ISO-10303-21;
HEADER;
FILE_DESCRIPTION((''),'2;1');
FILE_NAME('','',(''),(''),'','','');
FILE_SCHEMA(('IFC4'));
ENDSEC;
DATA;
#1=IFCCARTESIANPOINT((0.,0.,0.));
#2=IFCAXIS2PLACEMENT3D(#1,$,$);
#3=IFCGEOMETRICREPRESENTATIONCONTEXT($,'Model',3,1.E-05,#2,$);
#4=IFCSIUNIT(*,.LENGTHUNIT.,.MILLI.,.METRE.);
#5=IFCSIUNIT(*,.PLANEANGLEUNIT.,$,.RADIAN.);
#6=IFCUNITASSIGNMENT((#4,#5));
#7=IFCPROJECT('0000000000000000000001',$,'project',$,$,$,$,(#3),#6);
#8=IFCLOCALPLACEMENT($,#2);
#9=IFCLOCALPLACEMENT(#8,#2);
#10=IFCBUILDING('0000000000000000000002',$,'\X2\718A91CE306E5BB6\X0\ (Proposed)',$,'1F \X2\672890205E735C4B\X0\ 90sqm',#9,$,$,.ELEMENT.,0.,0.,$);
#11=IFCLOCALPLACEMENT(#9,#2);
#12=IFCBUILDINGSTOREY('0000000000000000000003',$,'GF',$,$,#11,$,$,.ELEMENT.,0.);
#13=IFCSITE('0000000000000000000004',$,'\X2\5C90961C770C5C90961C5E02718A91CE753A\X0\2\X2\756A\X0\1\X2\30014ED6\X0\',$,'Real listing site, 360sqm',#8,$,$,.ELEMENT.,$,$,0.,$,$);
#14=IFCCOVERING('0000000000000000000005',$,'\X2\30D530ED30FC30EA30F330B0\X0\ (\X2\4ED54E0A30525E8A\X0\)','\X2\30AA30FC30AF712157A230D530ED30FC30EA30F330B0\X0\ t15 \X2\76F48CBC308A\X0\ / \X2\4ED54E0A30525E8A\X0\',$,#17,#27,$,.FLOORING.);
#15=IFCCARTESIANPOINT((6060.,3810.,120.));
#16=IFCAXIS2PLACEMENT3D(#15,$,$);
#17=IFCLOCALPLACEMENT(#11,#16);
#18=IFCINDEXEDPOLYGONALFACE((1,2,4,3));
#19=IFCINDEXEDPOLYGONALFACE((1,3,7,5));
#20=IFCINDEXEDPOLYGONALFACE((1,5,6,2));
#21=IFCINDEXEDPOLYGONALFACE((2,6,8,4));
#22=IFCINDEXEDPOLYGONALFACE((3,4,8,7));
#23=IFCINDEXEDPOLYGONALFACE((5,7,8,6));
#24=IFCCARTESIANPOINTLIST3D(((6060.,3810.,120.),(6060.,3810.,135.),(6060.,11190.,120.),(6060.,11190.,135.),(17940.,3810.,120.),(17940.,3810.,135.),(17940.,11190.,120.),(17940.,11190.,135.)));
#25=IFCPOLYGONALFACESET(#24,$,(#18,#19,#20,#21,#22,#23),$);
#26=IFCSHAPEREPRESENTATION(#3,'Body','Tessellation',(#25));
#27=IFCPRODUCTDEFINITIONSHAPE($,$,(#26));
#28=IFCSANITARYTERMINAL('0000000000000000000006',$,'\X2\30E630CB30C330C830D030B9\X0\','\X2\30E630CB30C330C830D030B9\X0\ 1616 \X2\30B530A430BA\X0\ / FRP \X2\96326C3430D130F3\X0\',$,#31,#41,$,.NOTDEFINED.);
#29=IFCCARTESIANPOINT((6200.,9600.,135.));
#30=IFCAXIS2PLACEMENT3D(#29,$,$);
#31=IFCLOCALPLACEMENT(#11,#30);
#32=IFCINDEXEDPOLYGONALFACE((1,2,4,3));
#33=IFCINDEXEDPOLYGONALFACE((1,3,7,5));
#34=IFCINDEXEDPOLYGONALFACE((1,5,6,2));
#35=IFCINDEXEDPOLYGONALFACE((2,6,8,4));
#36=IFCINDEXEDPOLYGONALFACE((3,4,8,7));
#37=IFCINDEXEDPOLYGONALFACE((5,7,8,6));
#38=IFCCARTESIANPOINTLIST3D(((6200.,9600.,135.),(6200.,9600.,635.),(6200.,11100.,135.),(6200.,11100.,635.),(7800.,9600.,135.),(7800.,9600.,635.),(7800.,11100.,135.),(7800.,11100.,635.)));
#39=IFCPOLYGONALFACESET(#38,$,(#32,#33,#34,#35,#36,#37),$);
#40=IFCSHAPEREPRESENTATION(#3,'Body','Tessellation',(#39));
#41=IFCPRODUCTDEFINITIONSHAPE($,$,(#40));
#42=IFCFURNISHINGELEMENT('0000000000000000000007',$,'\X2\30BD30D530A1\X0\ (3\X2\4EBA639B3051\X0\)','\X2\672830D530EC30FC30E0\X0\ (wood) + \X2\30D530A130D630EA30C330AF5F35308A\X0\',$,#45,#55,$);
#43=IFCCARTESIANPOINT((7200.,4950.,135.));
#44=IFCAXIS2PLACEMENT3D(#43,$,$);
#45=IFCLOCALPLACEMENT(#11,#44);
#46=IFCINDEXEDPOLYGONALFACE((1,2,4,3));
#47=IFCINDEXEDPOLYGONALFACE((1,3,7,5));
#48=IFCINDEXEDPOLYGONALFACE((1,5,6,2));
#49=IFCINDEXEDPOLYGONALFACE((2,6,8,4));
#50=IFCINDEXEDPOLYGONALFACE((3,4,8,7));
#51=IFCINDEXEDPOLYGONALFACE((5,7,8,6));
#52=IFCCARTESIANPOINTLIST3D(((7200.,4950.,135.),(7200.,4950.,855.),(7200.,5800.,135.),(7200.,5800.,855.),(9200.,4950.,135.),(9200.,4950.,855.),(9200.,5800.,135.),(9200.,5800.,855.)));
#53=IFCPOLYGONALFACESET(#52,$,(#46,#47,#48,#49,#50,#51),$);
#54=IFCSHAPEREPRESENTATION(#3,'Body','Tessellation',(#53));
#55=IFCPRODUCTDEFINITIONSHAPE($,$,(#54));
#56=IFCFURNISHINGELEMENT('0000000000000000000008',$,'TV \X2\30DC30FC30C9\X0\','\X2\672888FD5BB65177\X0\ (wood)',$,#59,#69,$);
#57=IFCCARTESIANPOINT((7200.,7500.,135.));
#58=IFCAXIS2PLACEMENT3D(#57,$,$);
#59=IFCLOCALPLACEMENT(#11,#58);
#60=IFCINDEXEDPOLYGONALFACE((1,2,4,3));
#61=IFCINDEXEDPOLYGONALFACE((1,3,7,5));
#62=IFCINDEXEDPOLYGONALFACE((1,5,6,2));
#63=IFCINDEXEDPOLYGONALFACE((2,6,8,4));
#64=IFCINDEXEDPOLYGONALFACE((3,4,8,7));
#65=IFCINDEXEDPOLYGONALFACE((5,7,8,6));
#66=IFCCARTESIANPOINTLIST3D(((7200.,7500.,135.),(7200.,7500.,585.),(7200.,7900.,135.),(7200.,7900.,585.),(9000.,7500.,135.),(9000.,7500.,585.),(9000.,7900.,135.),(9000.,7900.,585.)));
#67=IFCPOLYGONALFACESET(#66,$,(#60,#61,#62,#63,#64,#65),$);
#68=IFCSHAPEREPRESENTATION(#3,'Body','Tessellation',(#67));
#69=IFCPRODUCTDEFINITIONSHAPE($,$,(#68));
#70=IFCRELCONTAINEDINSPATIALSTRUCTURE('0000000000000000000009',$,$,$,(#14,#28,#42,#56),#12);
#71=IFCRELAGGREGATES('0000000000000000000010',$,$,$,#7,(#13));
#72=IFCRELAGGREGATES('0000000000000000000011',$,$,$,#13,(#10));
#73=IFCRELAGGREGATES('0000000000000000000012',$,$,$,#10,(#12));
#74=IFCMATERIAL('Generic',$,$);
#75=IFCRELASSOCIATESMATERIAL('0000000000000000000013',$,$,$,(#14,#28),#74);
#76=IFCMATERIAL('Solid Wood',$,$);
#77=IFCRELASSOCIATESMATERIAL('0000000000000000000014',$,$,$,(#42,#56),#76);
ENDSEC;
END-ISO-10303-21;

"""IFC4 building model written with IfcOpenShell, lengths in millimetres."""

from ifc_helpers import new_model, si_unit, frame, frame_2d, origin, place, context, project, spatial, rectangle, extrude, material, element, save


model = new_model("IFC4")

# Units and contexts
model_context = context("Model", 3, precision=1e-05, world=origin())
ifc_project = project(units=[si_unit("LENGTHUNIT", "METRE", prefix="MILLI"), si_unit("PLANEANGLEUNIT", "RADIAN")], contexts=[model_context])

# Site, building, storey
site_placement = place(None, origin())
site = spatial("IfcSite", under=ifc_project, at=site_placement, Name="岐阜県岐阜市熊野町2番1、他", ObjectType="Real listing site, 360sqm", CompositionType="ELEMENT", RefElevation=0.0)
building_placement = place(site_placement, origin())
building = spatial("IfcBuilding", under=site, at=building_placement, Name="熊野の家 (Proposed)", ObjectType="1F 木造平屋 90sqm", CompositionType="ELEMENT", ElevationOfRefHeight=0.0, ElevationOfTerrain=0.0)
storey_placement = place(building_placement, origin())
storey = spatial("IfcBuildingStorey", under=building, at=storey_placement, Name="GF", CompositionType="ELEMENT", Elevation=0.0)

# Shared definitions
ifc_material_1 = material(Name="Solid Wood")

# Covering
ifc_material_2 = material(Name="Generic")
covering_placement = place(storey_placement, frame((6060.0, 3810.0, 120.0)))
element("IfcCovering", 1, at=covering_placement, inside=storey, material=ifc_material_2, Name="フローリング (仕上げ床)", Description="オーク無垢フローリング t15 直貼り / 仕上げ床", PredefinedType="FLOORING", context=model_context, shape_type="SweptSolid", body=[
    extrude(rectangle(XDim=11880.0, YDim=7380.0, at=frame_2d((5940.0, 3690.0))), frame((6060.0, 3810.0, 120.0)), (0.0, 0.0, 1.0), 15.0),
])

# Sanitary terminal
sanitary_terminal_placement = place(storey_placement, frame((6200.0, 9600.0, 135.0)))
element("IfcSanitaryTerminal", 2, at=sanitary_terminal_placement, inside=storey, material=ifc_material_2, Name="ユニットバス", Description="ユニットバス 1616 サイズ / FRP 防水パン", PredefinedType="NOTDEFINED", context=model_context, shape_type="SweptSolid", body=[
    extrude(rectangle(XDim=1600.0, YDim=1500.0, at=frame_2d((800.0, 750.0))), frame((6200.0, 9600.0, 135.0)), (0.0, 0.0, 1.0), 500.0),
])

# Furnishing elements
furnishing_1_placement = place(storey_placement, frame((7200.0, 4950.0, 135.0)))
element("IfcFurnishingElement", 3, at=furnishing_1_placement, inside=storey, material=ifc_material_1, Name="ソファ (3人掛け)", Description="木フレーム (wood) + ファブリック張り", context=model_context, shape_type="SweptSolid", body=[
    extrude(rectangle(XDim=2000.0, YDim=850.0, at=frame_2d((1000.0, 425.0))), frame((7200.0, 4950.0, 135.0)), (0.0, 0.0, 1.0), 720.0),
])
furnishing_2_placement = place(storey_placement, frame((7200.0, 7500.0, 135.0)))
element("IfcFurnishingElement", 4, at=furnishing_2_placement, inside=storey, material=ifc_material_1, Name="TV ボード", Description="木製家具 (wood)", context=model_context, shape_type="SweptSolid", body=[
    extrude(rectangle(XDim=1800.0, YDim=400.0, at=frame_2d((900.0, 200.0))), frame((7200.0, 7500.0, 135.0)), (0.0, 0.0, 1.0), 450.0),
])

save(model, "model.ifc")
